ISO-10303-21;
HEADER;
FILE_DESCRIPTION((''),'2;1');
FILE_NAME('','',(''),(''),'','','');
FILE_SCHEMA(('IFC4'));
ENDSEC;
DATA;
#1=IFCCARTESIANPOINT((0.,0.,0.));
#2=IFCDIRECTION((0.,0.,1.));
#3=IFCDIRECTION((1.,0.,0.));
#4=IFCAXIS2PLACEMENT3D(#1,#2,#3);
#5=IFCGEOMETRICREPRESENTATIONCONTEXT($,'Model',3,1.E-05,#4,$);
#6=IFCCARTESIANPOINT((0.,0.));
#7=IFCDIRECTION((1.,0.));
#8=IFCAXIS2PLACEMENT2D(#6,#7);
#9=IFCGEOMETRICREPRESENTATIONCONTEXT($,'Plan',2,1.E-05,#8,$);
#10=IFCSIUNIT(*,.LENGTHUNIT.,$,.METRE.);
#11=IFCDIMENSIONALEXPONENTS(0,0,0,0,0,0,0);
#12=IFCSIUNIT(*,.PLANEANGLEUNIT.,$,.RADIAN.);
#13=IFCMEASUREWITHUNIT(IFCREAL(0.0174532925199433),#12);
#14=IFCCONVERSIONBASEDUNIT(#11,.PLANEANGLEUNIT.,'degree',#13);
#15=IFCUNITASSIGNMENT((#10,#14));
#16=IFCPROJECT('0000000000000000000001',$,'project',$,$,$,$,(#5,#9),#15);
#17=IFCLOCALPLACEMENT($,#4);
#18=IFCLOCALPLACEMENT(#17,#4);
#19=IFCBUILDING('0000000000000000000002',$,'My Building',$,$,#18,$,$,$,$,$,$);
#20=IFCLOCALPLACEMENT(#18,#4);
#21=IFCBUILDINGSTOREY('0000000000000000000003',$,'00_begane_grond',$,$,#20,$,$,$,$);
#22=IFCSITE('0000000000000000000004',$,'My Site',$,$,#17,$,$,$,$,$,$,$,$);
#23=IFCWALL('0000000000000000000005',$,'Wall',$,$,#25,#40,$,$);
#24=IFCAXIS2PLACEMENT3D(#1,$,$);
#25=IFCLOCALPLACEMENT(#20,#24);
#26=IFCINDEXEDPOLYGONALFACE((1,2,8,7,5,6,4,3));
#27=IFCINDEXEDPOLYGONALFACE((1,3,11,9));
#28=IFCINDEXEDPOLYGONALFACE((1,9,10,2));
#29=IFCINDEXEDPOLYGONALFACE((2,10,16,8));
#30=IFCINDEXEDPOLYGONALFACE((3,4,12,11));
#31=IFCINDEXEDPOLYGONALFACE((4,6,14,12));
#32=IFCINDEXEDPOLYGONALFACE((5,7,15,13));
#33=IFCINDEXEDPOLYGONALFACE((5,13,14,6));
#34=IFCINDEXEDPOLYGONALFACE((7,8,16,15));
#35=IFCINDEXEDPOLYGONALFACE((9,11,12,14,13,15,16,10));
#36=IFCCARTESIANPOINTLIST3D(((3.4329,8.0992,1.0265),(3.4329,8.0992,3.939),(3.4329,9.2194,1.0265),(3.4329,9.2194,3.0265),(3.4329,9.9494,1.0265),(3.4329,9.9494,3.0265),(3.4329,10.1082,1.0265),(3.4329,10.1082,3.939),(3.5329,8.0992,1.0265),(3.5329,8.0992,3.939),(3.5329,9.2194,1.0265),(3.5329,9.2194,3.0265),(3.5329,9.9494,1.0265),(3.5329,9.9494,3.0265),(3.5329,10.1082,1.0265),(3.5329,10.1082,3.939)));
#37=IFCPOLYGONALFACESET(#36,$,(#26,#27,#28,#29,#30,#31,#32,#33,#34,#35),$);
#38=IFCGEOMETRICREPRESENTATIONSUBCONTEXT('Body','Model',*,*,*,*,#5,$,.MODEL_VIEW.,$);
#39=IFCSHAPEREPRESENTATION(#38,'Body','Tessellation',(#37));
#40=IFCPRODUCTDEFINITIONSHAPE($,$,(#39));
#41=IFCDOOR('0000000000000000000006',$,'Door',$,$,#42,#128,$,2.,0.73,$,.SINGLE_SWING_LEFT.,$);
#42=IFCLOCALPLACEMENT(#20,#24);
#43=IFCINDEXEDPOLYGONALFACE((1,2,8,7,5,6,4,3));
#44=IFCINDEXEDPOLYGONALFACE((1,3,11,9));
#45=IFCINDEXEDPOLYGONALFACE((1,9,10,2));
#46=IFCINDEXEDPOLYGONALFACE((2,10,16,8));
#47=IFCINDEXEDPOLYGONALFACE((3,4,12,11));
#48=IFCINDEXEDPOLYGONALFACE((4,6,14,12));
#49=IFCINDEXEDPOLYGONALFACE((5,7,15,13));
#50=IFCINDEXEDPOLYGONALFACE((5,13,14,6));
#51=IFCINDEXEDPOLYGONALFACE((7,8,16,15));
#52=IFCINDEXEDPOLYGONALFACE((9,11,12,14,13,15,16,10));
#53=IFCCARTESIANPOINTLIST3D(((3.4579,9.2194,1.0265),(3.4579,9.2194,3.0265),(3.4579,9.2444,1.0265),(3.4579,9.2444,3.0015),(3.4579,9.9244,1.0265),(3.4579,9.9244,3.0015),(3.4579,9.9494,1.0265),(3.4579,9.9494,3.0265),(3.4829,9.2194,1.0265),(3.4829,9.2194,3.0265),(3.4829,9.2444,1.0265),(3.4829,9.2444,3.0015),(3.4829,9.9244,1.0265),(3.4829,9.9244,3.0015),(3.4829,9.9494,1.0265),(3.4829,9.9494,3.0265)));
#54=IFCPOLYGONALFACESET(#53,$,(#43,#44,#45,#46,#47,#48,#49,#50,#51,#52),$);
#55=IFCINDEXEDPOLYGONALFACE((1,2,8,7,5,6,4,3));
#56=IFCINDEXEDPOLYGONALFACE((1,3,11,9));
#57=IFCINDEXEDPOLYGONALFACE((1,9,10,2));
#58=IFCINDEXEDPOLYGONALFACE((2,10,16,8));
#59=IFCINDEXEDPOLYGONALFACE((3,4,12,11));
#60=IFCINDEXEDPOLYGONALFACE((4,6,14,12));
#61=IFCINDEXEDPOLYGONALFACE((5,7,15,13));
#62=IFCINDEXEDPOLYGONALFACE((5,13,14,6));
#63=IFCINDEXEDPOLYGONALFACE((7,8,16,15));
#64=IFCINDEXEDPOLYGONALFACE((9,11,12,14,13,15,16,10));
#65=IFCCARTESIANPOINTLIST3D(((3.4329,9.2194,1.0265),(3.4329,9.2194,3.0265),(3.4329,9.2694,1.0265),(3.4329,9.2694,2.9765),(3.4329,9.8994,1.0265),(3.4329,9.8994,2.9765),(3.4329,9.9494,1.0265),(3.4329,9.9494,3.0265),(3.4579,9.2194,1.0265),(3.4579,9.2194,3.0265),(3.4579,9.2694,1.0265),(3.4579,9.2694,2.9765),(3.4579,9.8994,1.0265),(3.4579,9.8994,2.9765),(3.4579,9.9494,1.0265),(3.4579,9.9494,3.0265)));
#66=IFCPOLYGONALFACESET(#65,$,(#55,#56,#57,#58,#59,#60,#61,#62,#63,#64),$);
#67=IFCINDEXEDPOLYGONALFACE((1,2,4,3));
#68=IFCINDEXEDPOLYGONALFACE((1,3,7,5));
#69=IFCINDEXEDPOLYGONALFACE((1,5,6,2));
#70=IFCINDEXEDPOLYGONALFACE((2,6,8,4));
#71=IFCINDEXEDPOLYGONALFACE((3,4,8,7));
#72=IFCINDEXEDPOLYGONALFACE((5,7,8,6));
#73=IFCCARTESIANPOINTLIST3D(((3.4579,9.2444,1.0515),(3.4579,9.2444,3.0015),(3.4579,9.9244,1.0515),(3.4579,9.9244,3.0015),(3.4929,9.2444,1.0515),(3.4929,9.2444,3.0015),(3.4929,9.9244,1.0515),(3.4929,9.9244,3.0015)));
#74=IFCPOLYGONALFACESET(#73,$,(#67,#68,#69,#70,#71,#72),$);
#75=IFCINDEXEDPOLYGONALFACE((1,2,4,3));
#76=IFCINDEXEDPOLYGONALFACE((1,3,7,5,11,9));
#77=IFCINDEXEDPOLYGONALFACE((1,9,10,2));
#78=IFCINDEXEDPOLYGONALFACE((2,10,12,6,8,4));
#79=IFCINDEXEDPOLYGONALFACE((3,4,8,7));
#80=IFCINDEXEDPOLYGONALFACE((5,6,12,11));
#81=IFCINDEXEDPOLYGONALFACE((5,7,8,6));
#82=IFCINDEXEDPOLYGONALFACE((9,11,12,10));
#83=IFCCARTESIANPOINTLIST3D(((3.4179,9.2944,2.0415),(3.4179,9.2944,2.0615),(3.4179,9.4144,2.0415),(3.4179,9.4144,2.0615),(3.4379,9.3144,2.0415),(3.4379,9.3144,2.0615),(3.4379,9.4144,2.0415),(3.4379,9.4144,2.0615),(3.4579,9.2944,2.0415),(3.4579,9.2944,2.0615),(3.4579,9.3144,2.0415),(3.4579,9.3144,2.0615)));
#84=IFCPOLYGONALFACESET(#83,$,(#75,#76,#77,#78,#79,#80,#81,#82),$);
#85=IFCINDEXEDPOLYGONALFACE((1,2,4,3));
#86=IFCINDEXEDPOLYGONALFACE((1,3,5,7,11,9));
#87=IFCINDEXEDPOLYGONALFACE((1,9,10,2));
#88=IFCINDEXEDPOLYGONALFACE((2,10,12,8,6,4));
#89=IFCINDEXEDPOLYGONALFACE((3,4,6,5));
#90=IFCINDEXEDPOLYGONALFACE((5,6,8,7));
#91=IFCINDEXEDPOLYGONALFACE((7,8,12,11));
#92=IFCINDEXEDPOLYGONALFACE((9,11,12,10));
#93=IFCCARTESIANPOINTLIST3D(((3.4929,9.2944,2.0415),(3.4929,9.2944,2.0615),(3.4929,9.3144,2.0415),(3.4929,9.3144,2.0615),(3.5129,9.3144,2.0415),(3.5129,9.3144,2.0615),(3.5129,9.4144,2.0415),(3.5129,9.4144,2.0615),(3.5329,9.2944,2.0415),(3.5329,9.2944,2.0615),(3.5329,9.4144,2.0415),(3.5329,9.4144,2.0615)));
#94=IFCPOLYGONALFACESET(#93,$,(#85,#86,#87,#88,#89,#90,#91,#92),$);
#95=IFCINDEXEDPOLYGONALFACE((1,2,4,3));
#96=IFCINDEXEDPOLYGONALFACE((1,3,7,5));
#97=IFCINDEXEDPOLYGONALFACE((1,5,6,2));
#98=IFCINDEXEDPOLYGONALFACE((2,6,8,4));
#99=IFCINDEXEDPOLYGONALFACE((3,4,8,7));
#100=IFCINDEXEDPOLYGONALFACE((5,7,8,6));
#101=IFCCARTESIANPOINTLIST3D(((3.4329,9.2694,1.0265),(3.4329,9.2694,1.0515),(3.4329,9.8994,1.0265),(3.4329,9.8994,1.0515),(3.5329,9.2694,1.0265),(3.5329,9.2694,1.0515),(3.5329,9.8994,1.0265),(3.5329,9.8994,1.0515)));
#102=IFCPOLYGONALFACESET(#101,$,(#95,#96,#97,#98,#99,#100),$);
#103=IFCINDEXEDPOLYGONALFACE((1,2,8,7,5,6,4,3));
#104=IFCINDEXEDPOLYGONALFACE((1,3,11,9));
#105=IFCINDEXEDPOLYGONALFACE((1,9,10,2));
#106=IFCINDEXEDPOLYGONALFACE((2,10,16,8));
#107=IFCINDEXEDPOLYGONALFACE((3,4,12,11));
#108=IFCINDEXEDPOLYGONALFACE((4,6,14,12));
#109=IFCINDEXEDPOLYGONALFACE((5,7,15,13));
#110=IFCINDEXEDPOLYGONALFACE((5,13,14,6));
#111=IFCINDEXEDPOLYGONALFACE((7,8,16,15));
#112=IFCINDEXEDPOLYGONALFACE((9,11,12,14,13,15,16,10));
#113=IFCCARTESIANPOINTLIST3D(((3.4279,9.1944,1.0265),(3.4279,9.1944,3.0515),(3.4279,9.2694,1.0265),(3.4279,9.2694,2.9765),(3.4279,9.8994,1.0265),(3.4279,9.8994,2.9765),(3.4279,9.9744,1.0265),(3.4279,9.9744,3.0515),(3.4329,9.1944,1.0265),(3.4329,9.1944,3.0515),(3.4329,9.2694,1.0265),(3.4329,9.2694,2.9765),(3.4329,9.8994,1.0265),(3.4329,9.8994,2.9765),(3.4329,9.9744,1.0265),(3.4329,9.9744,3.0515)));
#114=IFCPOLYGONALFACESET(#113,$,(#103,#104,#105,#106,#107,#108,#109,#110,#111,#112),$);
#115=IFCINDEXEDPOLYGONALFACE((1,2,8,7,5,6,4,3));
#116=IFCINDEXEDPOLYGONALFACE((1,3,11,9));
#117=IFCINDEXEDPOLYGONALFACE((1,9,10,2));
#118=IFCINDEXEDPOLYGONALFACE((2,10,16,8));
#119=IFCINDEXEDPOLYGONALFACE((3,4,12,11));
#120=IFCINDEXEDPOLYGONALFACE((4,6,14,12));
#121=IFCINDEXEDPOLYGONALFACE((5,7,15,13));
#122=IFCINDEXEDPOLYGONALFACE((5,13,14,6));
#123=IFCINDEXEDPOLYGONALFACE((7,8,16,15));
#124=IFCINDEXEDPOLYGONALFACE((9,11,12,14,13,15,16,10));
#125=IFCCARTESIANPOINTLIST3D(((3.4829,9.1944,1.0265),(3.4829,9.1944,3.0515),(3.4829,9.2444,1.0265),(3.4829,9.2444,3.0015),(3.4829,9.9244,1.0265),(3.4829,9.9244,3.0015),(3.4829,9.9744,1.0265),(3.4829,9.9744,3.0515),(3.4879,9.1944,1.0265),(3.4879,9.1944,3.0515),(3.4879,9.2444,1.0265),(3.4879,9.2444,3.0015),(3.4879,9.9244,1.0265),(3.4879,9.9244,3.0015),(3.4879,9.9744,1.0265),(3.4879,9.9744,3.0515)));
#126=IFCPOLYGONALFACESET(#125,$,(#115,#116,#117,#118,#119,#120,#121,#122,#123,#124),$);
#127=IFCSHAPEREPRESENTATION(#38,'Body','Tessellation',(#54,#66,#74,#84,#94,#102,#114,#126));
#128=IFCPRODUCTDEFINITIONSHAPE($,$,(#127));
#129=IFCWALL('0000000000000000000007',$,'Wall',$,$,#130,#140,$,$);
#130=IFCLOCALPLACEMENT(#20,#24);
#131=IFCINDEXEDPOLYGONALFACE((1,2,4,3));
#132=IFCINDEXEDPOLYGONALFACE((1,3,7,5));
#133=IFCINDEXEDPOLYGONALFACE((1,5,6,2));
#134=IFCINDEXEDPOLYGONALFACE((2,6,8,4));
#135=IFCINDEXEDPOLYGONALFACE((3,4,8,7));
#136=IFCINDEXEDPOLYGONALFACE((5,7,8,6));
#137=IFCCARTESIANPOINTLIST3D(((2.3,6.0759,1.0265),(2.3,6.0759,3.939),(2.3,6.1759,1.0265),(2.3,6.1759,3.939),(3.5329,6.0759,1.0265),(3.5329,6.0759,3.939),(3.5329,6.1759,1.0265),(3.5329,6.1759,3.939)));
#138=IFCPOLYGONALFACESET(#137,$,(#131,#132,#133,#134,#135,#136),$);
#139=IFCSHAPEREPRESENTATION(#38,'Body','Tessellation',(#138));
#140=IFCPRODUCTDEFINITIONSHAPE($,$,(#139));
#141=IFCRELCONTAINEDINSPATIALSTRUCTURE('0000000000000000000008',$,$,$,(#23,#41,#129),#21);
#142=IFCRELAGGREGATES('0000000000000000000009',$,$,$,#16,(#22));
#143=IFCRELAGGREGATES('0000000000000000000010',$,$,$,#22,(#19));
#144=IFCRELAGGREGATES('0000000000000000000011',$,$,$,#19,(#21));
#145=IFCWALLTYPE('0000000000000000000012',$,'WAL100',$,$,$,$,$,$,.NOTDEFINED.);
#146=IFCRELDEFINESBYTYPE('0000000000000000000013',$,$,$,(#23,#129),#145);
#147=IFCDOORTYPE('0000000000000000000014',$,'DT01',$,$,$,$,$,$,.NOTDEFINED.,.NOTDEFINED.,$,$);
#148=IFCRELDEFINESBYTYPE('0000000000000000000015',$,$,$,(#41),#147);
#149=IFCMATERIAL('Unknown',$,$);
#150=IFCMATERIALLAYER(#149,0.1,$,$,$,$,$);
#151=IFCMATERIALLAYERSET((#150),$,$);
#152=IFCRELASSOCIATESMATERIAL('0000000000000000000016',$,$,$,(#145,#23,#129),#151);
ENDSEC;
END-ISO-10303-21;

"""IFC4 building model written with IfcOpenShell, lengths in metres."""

from ifc_helpers import new_model, entity, si_unit, converted_unit, frame, origin_with_axes, origin_2d_with_axis, place, context, subcontext, project, spatial, line, indexed_curve, outline, extrude, shape, source, transform, mapped, material, layer, layer_set, layer_usage, type_object, type_shapes, element, fill, save


model = new_model("IFC4")

# Units and contexts
model_context = context("Model", 3, precision=1e-05, world=origin_with_axes())
plan_context = context("Plan", 2, precision=1e-05, world=origin_2d_with_axis())
body_context_1 = subcontext(model_context, "Body", "Model", "MODEL_VIEW")
body_context_2 = subcontext(plan_context, "Body", "Plan", "PLAN_VIEW")
ifc_project = project(units=[si_unit("LENGTHUNIT", "METRE"), converted_unit("PLANEANGLEUNIT", "degree", entity("IfcReal", 0.0174532925199433), si_unit("PLANEANGLEUNIT", "RADIAN"), dimensions=[0, 0, 0, 0, 0, 0, 0])], contexts=[model_context, plan_context])

# Site, building, storey
site_placement = place(None, origin_with_axes())
site = spatial("IfcSite", under=ifc_project, at=site_placement, Name="My Site")
building_placement = place(site_placement, origin_with_axes())
building = spatial("IfcBuilding", under=site, at=building_placement, Name="My Building")
storey_placement = place(building_placement, origin_with_axes())
storey = spatial("IfcBuildingStorey", under=building, at=storey_placement, Name="00_begane_grond")

# Shared definitions
ifc_material_1 = material(Name="Unknown")

# Shared definitions
ifc_layer_1 = layer(ifc_material_1, 0.1)
ifc_layer_set_1 = layer_set([ifc_layer_1])
wall_type_1 = type_object("IfcWallType", Name="WAL100", PredefinedType="NOTDEFINED", material=ifc_layer_set_1)

# Shared definitions
shared_shape_1 = source(origin_with_axes(), body_context_1, "Body", "SweptSolid", [
    extrude(outline(indexed_curve([(0.0, 0.0), (0.73, 0.0), (0.73, 2.0), (0.0, 2.0)], segments=[line(1, 2, 3, 4, 1)])), frame((0.0, -0.1, 0.0), z_axis=(0.0, -1.0, 0.0), x_axis=(1.0, 0.0, 0.0)), (0.0, 0.0, -1.0), 0.3),
])
door_type_1 = type_object("IfcDoorType", Name="DT01", OperationType="NOTDEFINED", PredefinedType="NOTDEFINED")
shared_shape_2 = source(origin_with_axes(), body_context_1, "Body", "SweptSolid", [
    extrude(outline(indexed_curve([(0.025, 0.0), (0.025, 1.975), (0.705, 1.975), (0.705, 0.0), (0.73, 0.0), (0.73, 2.0), (0.0, 2.0), (0.0, 0.0)], segments=[line(3, 2), line(2, 1), line(1, 8), line(8, 7), line(7, 6), line(6, 5), line(5, 4), line(4, 3)], self_intersect=False)), frame((0.0, 0.025, 0.0), z_axis=(0.0, -1.0, 0.0), x_axis=(1.0, 0.0, 0.0)), (0.0, 0.0, -1.0), 0.025),
    extrude(outline(indexed_curve([(0.0, 0.0), (0.0, 2.0), (0.73, 2.0), (0.73, 0.0), (0.68, 0.0), (0.68, 1.95), (0.05, 1.95), (0.05, 0.0)], segments=[line(1, 2, 3, 4, 5, 6, 7, 8, 1)])), frame((0.0, 0.0, 0.0), z_axis=(0.0, -1.0, 0.0), x_axis=(1.0, 0.0, 0.0)), (0.0, 0.0, -1.0), 0.025),
    extrude(outline(indexed_curve([(0.0, 0.0), (0.68, 0.0), (0.68, 0.035), (0.0, 0.035)], segments=[line(1, 2, 3, 4, 1)])), frame((0.025, 0.025, 0.025), z_axis=(0.0, 0.0, 1.0), x_axis=(1.0, 0.0, 0.0)), (0.0, 0.0, 1.0), 1.95),
    extrude(outline(indexed_curve([(0.0, 0.0), (0.0, -0.04), (-0.12, -0.04), (-0.12, -0.02), (-0.02, -0.02), (-0.02, 0.0)], segments=[line(1, 2, 3, 4, 5, 6, 1)])), frame((0.655, 0.025, 1.015), z_axis=(0.0, 0.0, 1.0), x_axis=(1.0, 0.0, 0.0)), (0.0, 0.0, 1.0), 0.02),
    extrude(outline(indexed_curve([(0.0, 0.0), (0.0, 0.04), (-0.12, 0.04), (-0.12, 0.02), (-0.02, 0.02), (-0.02, 0.0)], segments=[line(1, 2, 3, 4, 5, 6, 1)])), frame((0.655, 0.06, 1.015), z_axis=(0.0, 0.0, 1.0), x_axis=(1.0, 0.0, 0.0)), (0.0, 0.0, 1.0), 0.02),
    extrude(outline(indexed_curve([(0.0, 0.0), (0.63, 0.0), (0.63, 0.1), (0.0, 0.1)], segments=[line(1, 2, 3, 4, 1)])), frame((0.05, 0.0, 0.0), z_axis=(0.0, 0.0, 1.0), x_axis=(1.0, 0.0, 0.0)), (0.0, 0.0, 1.0), 0.025),
    extrude(outline(indexed_curve([(0.0, 0.0), (0.0, 2.025), (0.78, 2.025), (0.78, 0.0), (0.705, 0.0), (0.705, 1.95), (0.075, 1.95), (0.075, 0.0)], segments=[line(1, 2, 3, 4, 5, 6, 7, 8, 1)])), frame((-0.025, -0.005, 0.0), z_axis=(0.0, -1.0, 0.0), x_axis=(1.0, 0.0, 0.0)), (0.0, 0.0, -1.0), 0.005),
    extrude(outline(indexed_curve([(0.0, 0.0), (0.0, 2.025), (0.78, 2.025), (0.78, 0.0), (0.73, 0.0), (0.73, 1.975), (0.05, 1.975), (0.05, 0.0)], segments=[line(1, 2, 3, 4, 5, 6, 7, 8, 1)])), frame((-0.025, 0.05, 0.0), z_axis=(0.0, -1.0, 0.0), x_axis=(1.0, 0.0, 0.0)), (0.0, 0.0, -1.0), 0.005),
])
shared_shape_3 = source(origin_with_axes(), body_context_2, "Body", "Curve2D", [
    entity("IfcIndexedPolyCurve", entity("IfcCartesianPointList2D", [[0.0, 0.0], [0.0, 0.05], [0.025, 0.05], [0.025, 0.025], [0.05, 0.025], [0.05, 0.0]]), [entity("IfcLineIndex", [1, 2, 3, 4, 5, 6, 1])]),
    entity("IfcIndexedPolyCurve", entity("IfcCartesianPointList2D", [[0.73, 0.0], [0.73, 0.05], [0.705, 0.05], [0.705, 0.025], [0.68, 0.025], [0.68, 0.0]]), [entity("IfcLineIndex", [1, 2, 3, 4, 5, 6, 1])]),
    entity("IfcTrimmedCurve", entity("IfcEllipse", entity("IfcAxis2Placement2D", entity("IfcCartesianPoint", [0.06, 0.05]), entity("IfcDirection", [1.0, 0.0])), 0.645, 0.68), [entity("IfcCartesianPoint", [0.705, 0.05])], [entity("IfcCartesianPoint", [0.06, 0.73])], True, "CARTESIAN"),
    entity("IfcIndexedPolyCurve", entity("IfcCartesianPointList2D", [[0.025, 0.05], [0.06, 0.05], [0.06, 0.73], [0.025, 0.73]]), [entity("IfcLineIndex", [1, 2, 3, 4, 1])]),
])
type_shapes(door_type_1, [shared_shape_2, shared_shape_3])

# Wall, opening, door
ifc_layer_usage_1 = layer_usage(ifc_layer_set_1, "AXIS2", "POSITIVE", 0.0)
wall_1_placement = place(storey_placement, frame((3.5329, 8.0992, 1.0265), z_axis=(0.0, 0.0, 1.0), x_axis=(0.000001, 1.0, 0.0)))
wall_1 = element("IfcWall", 1, at=wall_1_placement, inside=storey, type_object=wall_type_1, material=ifc_layer_usage_1, Name="Wall", context=body_context_1, shape_type="SweptSolid", body=[
    extrude(outline(indexed_curve([(0.0, 0.0), (0.0, 0.1), (2.009, 0.1), (2.009, 0.0), (0.0, 0.0)], self_intersect=False)), origin_with_axes(), (0.0, 0.0, 1.0), 2.9125),
])
opening_1_placement = place(wall_1_placement, frame((1.8502, 0.1, 0.0), z_axis=(0.0, 0.0, 1.0), x_axis=(-1.0, 0.0, 0.0)))
opening_1 = element("IfcOpeningElement", 2, at=opening_1_placement, cuts=wall_1, PredefinedType="OPENING", context=body_context_1, shape_type="MappedRepresentation", body=[
    mapped(shared_shape_1, transform((0.0, 0.0, 0.0), x_axis=(1.0, 0.0, 0.0), y_axis=(0.0, 1.0, 0.0), z_axis=(0.0, 0.0, 1.0), scale=1.0)),
])
door_1_placement = place(opening_1_placement, frame((0.0, 0.0, 0.0), z_axis=(0.0, 0.0, 1.0), x_axis=(1.0, 0.0, 0.0)))
door_1 = element("IfcDoor", 3, at=door_1_placement, inside=storey, type_object=door_type_1, Name="Door", OperationType="SINGLE_SWING_LEFT", OverallHeight=2.0, OverallWidth=0.73, shapes=[
    shape(body_context_1, "Body", "MappedRepresentation", [mapped(shared_shape_2, transform((0.0, 0.0, 0.0), x_axis=(1.0, 0.0, 0.0), y_axis=(0.0, 1.0, 0.0), z_axis=(0.0, 0.0, 1.0), scale=1.0))]),
    shape(body_context_2, "Body", "MappedRepresentation", [mapped(shared_shape_3, transform((0.0, 0.0, 0.0), x_axis=(1.0, 0.0, 0.0), y_axis=(0.0, 1.0, 0.0), z_axis=(0.0, 0.0, 1.0), scale=1.0))]),
])
fill(opening_1, door_1)

# Wall
ifc_layer_usage_2 = layer_usage(ifc_layer_set_1, "AXIS2", "POSITIVE", 0.0)
wall_2_placement = place(storey_placement, frame((2.3, 6.0759, 1.0265), z_axis=(0.0, 0.0, 1.0), x_axis=(1.0, -0.000001, 0.0)))
element("IfcWall", 4, at=wall_2_placement, inside=storey, type_object=wall_type_1, material=ifc_layer_usage_2, Name="Wall", context=body_context_1, shape_type="SweptSolid", body=[
    extrude(outline(indexed_curve([(0.0, 0.0), (0.0, 0.1), (1.2329, 0.1), (1.2329, 0.0), (0.0, 0.0)], self_intersect=False)), origin_with_axes(), (0.0, 0.0, 1.0), 2.9125),
])

save(model, "model.ifc")
